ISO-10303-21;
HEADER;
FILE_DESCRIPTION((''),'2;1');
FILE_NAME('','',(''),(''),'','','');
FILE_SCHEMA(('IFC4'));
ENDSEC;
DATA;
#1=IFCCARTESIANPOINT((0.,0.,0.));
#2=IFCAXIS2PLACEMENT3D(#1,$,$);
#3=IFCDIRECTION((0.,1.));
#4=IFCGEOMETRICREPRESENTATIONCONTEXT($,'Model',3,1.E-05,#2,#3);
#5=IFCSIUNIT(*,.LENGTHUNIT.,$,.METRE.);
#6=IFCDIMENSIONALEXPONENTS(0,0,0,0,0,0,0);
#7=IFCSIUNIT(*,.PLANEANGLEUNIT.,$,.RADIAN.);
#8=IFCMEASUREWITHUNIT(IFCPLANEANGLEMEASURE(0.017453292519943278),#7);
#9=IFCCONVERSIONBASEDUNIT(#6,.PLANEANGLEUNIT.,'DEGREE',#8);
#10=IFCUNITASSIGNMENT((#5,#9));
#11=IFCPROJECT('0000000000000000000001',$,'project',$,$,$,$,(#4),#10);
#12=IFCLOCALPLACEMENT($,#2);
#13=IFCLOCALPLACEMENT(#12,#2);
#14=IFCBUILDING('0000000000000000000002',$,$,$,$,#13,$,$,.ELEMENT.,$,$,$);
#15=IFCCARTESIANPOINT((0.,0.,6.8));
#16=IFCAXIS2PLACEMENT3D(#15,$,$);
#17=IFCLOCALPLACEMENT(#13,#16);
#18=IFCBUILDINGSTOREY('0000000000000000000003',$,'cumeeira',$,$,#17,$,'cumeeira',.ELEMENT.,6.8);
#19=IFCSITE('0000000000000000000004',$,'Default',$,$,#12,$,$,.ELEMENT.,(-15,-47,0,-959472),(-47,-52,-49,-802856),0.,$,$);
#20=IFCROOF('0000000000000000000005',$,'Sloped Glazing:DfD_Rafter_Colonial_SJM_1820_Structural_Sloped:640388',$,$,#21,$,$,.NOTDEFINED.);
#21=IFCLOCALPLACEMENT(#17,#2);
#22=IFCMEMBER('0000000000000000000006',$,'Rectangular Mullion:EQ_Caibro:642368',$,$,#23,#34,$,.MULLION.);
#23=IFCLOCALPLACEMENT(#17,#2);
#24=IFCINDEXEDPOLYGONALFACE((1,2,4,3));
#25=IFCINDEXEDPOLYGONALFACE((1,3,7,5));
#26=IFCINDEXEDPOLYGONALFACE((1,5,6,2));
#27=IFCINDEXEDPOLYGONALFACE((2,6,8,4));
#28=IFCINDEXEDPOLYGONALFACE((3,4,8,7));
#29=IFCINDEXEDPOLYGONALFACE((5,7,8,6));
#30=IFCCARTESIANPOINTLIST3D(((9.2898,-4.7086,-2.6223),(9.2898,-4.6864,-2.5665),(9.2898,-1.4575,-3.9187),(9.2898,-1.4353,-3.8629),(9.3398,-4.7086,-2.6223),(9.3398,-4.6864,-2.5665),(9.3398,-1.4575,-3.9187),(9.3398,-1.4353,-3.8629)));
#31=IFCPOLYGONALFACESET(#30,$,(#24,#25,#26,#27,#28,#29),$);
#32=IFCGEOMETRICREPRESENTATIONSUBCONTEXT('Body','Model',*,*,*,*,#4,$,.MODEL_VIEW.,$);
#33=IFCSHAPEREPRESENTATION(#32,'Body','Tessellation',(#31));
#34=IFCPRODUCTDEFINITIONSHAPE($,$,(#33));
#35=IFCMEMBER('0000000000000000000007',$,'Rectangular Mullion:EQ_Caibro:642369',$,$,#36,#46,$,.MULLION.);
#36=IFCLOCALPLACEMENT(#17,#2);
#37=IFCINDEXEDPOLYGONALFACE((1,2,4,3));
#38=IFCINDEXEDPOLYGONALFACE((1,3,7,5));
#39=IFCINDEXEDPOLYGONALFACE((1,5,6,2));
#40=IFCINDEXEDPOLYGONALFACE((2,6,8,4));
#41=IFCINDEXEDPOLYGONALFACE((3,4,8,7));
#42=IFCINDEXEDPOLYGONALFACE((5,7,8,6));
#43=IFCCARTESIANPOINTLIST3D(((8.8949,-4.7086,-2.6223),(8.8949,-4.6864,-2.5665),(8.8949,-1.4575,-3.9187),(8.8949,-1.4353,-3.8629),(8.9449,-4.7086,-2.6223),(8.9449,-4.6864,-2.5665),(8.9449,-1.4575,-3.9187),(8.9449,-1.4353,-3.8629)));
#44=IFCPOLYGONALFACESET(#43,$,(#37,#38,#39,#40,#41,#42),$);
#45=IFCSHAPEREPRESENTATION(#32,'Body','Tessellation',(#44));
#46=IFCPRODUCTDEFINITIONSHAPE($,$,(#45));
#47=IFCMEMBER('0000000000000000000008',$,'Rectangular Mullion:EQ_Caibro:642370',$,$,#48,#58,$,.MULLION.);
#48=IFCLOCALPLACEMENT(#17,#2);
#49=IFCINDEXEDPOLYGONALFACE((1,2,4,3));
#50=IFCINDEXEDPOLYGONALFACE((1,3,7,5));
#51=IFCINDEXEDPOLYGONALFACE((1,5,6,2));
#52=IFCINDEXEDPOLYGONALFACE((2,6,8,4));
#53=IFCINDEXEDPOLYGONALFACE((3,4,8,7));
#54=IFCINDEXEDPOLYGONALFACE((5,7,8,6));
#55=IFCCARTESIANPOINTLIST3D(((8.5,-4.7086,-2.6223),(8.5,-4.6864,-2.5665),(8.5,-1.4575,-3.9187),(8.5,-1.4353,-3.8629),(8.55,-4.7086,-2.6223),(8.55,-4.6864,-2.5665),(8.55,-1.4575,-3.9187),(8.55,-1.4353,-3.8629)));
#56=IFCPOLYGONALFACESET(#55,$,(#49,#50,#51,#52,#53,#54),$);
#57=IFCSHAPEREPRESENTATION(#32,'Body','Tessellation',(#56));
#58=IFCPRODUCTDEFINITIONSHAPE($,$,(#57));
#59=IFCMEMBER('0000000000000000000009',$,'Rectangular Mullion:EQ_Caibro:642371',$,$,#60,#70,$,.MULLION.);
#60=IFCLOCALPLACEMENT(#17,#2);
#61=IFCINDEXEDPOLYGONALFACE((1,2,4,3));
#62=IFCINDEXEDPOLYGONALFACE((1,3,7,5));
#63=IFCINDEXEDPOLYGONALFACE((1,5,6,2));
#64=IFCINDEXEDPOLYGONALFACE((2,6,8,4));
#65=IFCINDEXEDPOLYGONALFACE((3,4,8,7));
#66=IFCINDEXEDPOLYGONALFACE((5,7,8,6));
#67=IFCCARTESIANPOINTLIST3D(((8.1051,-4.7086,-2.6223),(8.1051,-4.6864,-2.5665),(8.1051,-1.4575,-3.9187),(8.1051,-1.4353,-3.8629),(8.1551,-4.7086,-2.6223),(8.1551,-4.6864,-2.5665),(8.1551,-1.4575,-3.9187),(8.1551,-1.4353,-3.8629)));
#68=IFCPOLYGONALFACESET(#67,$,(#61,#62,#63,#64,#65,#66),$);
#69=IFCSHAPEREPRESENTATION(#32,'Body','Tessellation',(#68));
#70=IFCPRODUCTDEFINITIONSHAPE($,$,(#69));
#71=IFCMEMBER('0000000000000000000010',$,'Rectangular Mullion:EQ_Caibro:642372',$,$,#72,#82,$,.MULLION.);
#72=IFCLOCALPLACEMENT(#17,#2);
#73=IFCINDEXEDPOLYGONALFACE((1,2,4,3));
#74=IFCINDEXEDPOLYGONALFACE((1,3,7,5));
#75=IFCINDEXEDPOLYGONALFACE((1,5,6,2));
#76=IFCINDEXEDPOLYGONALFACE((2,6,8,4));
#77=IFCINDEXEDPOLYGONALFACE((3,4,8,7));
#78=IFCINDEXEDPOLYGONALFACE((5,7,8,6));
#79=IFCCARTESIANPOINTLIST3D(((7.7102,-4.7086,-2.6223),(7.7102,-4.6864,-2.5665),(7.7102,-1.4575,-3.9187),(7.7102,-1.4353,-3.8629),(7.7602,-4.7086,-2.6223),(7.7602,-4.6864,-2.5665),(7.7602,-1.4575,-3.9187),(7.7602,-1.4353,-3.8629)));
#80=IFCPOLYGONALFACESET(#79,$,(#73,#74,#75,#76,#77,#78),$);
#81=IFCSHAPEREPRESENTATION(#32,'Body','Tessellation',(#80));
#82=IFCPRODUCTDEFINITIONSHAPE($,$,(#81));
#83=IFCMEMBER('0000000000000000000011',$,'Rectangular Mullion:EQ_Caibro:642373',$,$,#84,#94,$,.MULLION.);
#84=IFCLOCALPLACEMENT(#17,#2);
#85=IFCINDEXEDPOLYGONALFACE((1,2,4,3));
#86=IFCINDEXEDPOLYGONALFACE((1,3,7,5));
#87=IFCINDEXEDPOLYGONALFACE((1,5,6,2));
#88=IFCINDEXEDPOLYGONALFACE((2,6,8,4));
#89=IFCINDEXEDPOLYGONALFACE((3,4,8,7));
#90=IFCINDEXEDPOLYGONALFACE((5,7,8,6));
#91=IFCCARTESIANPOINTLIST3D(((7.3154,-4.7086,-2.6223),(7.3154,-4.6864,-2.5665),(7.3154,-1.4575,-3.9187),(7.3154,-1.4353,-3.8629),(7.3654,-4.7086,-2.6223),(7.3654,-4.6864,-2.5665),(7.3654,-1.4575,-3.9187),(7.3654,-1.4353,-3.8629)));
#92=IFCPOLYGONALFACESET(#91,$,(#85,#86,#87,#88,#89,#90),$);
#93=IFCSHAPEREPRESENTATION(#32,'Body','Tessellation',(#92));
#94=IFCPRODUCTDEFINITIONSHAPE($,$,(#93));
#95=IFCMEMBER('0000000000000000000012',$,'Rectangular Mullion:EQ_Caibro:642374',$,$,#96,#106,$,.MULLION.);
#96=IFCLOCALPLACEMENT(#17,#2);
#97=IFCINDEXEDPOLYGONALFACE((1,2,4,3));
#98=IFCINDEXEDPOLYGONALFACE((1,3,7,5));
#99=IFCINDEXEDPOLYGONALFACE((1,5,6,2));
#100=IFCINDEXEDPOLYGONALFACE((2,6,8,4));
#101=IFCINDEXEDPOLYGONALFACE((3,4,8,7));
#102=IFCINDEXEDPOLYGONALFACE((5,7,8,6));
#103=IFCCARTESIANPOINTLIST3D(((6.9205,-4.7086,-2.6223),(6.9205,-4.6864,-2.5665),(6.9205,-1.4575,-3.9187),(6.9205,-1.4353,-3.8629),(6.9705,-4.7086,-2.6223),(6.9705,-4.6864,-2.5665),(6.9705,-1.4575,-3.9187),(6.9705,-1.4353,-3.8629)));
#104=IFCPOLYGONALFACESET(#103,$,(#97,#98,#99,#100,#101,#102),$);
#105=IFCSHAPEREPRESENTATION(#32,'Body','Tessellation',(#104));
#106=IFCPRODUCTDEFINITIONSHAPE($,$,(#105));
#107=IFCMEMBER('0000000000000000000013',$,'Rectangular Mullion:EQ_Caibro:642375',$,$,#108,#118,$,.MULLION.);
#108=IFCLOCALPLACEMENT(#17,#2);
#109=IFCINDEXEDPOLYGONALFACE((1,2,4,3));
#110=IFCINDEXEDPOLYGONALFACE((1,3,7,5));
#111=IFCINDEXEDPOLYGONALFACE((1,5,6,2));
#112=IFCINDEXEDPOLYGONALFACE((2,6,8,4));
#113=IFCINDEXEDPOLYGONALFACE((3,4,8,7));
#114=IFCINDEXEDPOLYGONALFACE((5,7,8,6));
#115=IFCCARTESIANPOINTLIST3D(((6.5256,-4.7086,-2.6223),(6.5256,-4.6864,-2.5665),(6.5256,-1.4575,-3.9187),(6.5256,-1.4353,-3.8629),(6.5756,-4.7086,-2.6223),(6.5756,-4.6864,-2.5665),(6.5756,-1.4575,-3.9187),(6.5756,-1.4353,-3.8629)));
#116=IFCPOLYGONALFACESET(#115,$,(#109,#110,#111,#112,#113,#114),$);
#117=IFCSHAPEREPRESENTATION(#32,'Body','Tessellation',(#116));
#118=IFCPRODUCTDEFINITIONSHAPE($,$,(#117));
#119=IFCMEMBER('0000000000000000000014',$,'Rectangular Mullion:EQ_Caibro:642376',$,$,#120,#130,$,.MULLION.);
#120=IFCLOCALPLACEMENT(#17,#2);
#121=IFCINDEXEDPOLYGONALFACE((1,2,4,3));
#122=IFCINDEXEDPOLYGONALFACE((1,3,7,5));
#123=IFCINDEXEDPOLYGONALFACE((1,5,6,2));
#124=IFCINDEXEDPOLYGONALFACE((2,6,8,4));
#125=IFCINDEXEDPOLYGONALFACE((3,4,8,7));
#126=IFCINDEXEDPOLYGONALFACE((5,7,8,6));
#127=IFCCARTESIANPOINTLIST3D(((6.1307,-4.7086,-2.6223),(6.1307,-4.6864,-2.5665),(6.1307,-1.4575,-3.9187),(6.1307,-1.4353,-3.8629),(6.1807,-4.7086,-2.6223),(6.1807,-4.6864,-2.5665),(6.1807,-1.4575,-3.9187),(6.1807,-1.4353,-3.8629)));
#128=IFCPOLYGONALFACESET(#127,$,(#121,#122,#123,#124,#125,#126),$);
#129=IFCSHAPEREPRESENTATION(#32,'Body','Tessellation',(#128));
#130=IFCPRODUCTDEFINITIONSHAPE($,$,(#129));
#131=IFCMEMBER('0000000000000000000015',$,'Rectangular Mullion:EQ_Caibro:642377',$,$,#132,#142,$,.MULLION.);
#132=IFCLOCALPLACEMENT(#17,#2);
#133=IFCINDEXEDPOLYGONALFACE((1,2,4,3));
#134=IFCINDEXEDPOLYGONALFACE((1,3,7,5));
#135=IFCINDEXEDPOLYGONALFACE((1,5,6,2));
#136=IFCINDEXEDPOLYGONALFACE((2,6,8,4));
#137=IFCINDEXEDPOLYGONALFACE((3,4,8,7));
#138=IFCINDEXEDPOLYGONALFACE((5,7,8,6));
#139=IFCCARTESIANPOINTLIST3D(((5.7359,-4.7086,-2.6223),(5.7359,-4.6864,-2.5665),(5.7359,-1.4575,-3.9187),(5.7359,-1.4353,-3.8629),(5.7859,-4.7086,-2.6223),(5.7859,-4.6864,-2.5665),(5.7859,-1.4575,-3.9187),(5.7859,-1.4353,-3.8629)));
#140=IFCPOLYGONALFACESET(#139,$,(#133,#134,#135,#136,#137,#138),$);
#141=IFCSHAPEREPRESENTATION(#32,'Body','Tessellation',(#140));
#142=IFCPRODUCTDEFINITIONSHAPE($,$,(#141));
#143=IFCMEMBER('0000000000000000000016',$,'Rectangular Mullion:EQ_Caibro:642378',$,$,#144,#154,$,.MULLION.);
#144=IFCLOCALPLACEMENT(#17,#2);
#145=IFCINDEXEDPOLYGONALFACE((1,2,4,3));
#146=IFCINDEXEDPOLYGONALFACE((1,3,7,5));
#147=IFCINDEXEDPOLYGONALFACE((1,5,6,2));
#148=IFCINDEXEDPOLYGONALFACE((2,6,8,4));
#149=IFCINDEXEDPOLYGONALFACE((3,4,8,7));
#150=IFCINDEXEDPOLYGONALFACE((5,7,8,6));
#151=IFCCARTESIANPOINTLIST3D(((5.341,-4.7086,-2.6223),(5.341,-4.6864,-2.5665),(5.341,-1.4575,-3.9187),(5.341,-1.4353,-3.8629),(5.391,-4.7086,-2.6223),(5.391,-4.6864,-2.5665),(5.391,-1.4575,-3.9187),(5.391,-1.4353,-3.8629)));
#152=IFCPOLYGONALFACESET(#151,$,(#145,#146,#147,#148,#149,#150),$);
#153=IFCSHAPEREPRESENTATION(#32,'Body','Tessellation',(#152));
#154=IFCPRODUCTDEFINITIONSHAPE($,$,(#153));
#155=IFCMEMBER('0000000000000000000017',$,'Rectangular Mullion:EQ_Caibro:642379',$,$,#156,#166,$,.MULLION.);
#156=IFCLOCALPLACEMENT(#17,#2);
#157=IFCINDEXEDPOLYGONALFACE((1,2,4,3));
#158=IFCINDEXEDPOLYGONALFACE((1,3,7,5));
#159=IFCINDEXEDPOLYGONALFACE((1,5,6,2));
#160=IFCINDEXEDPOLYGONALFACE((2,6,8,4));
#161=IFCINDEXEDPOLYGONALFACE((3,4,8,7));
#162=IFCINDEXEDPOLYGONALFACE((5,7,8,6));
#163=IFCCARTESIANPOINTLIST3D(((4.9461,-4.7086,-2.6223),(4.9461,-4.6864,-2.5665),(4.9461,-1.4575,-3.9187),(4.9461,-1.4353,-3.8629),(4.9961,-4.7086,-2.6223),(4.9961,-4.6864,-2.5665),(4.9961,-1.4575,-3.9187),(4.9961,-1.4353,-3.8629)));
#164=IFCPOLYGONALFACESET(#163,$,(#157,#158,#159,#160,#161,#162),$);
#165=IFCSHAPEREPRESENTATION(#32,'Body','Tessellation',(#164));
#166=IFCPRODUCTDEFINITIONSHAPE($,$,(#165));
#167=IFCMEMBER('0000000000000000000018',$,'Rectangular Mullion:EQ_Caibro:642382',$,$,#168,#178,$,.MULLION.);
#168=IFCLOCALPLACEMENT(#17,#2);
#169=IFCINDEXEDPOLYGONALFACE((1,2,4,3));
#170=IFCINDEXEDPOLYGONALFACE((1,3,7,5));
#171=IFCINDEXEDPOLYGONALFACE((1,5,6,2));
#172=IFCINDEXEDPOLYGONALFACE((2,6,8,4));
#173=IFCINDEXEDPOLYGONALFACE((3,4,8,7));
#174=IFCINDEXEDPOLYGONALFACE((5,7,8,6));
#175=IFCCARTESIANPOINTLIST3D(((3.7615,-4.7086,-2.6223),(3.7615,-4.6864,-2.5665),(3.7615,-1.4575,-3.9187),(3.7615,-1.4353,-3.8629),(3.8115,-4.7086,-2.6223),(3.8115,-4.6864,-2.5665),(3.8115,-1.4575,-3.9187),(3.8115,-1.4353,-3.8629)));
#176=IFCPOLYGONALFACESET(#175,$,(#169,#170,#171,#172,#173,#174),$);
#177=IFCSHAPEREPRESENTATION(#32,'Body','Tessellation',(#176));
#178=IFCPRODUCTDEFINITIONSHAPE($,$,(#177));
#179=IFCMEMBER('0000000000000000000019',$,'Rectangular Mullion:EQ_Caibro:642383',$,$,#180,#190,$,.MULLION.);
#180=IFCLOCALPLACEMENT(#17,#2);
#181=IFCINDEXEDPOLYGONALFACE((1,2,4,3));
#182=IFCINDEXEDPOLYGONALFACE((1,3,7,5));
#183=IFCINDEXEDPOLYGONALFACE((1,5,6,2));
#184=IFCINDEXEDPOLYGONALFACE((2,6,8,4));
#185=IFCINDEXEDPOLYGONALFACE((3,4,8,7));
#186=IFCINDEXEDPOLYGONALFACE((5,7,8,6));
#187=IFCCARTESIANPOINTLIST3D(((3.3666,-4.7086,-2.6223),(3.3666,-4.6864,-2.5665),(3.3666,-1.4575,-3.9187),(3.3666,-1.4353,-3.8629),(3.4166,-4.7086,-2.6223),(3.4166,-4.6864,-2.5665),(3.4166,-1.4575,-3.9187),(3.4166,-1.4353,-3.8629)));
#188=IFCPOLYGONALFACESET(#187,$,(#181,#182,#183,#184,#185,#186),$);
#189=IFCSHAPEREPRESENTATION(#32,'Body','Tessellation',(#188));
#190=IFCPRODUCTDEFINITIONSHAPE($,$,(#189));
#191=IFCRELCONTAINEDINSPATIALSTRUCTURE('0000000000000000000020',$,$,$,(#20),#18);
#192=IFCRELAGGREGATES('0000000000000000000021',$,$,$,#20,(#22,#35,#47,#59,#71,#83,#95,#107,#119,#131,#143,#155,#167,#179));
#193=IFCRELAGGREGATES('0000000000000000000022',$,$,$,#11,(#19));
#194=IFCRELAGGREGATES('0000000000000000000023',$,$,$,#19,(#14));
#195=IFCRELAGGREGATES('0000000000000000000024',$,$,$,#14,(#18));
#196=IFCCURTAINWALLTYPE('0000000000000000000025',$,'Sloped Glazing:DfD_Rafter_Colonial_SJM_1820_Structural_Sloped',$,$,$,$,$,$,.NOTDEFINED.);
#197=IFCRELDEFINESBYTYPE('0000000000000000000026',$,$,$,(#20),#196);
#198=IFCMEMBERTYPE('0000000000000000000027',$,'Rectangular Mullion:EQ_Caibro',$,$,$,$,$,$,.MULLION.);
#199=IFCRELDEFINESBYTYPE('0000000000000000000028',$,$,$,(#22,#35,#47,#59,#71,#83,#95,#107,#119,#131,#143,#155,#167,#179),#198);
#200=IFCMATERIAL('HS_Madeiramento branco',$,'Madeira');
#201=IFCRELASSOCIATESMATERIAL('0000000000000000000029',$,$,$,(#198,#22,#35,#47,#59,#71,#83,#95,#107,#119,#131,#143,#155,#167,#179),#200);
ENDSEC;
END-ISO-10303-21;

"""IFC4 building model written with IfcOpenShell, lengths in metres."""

from ifc_helpers import new_model, entity, si_unit, converted_unit, direction, frame, origin, place, context, subcontext, project, spatial, indexed_curve, outline, extrude, source, transform, mapped, material, type_object, type_shapes, element, aggregate, save


model = new_model("IFC4")

# Units and contexts
model_context = context("Model", 3, precision=1e-05, world=origin(), true_north=direction((0.0, 1.0)))
body_context = subcontext(model_context, "Body", "Model", "MODEL_VIEW")
ifc_project = project(units=[si_unit("LENGTHUNIT", "METRE"), converted_unit("PLANEANGLEUNIT", "DEGREE", entity("IfcPlaneAngleMeasure", 0.017453292519943278), si_unit("PLANEANGLEUNIT", "RADIAN"), dimensions=[0, 0, 0, 0, 0, 0, 0])], contexts=[model_context])

# Site, building, storey
site_placement = place(None, origin())
site = spatial("IfcSite", under=ifc_project, at=site_placement, Name="Default", CompositionType="ELEMENT", RefLatitude=(-15, -47, 0, -959472), RefLongitude=(-47, -52, -49, -802856), RefElevation=0.0)
building_placement = place(site_placement, origin())
building = spatial("IfcBuilding", under=site, at=building_placement, CompositionType="ELEMENT")
storey_placement = place(building_placement, frame((0.0, 0.0, 6.8)))
storey = spatial("IfcBuildingStorey", under=building, at=storey_placement, Name="cumeeira", LongName="cumeeira", CompositionType="ELEMENT", Elevation=6.8)

# Roof, members
curtain_wall_type_1 = type_object("IfcCurtainWallType", Name="Sloped Glazing:DfD_Rafter_Colonial_SJM_1820_Structural_Sloped", PredefinedType="NOTDEFINED")
roof_1_placement = place(storey_placement, frame((0.0, 0.0, -6.8)))
roof_1 = element("IfcRoof", 1, at=roof_1_placement, inside=storey, type_object=curtain_wall_type_1, Name="Sloped Glazing:DfD_Rafter_Colonial_SJM_1820_Structural_Sloped:640388", PredefinedType="NOTDEFINED")
ifc_material_1 = material(Name="HS_Madeiramento branco", Category="Madeira")
member_type_1 = type_object("IfcMemberType", Name="Rectangular Mullion:EQ_Caibro", PredefinedType="MULLION", material=ifc_material_1)
shared_shape_1 = source(origin(), body_context, "Body", "SweptSolid", [
    extrude(outline(indexed_curve([(-0.025, -0.03), (0.025, -0.03), (0.025, 0.03), (-0.025, 0.03), (-0.025, -0.03)], self_intersect=False)), frame((0.0, -0.03, -3.5), z_axis=(0.0, 0.0, 1.0), x_axis=(-1.0, 0.0, 0.0)), (0.0, 0.0, 1.0), 3.5),
])
type_shapes(member_type_1, [shared_shape_1])
member_1_placement = place(roof_1_placement, frame((9.3148, -4.7086, 4.1777), z_axis=(0.0, -0.928874, 0.370395), x_axis=(-1.0, 0.0, 0.0)))
member_1 = element("IfcMember", 2, at=member_1_placement, type_object=member_type_1, material=ifc_material_1, Name="Rectangular Mullion:EQ_Caibro:642368", PredefinedType="MULLION", context=body_context, shape_type="MappedRepresentation", body=[
    mapped(shared_shape_1, transform((0.0, 0.0, 0.0), scale=1.0)),
])
member_2_placement = place(roof_1_placement, frame((8.9199, -4.7086, 4.1777), z_axis=(0.0, -0.928874, 0.370395), x_axis=(-1.0, 0.0, 0.0)))
member_2 = element("IfcMember", 3, at=member_2_placement, type_object=member_type_1, material=ifc_material_1, Name="Rectangular Mullion:EQ_Caibro:642369", PredefinedType="MULLION", context=body_context, shape_type="MappedRepresentation", body=[
    mapped(shared_shape_1, transform((0.0, 0.0, 0.0), scale=1.0)),
])
member_3_placement = place(roof_1_placement, frame((8.525, -4.7086, 4.1777), z_axis=(0.0, -0.928874, 0.370395), x_axis=(-1.0, 0.0, 0.0)))
member_3 = element("IfcMember", 4, at=member_3_placement, type_object=member_type_1, material=ifc_material_1, Name="Rectangular Mullion:EQ_Caibro:642370", PredefinedType="MULLION", context=body_context, shape_type="MappedRepresentation", body=[
    mapped(shared_shape_1, transform((0.0, 0.0, 0.0), scale=1.0)),
])
member_4_placement = place(roof_1_placement, frame((8.1301, -4.7086, 4.1777), z_axis=(0.0, -0.928874, 0.370395), x_axis=(-1.0, 0.0, 0.0)))
member_4 = element("IfcMember", 5, at=member_4_placement, type_object=member_type_1, material=ifc_material_1, Name="Rectangular Mullion:EQ_Caibro:642371", PredefinedType="MULLION", context=body_context, shape_type="MappedRepresentation", body=[
    mapped(shared_shape_1, transform((0.0, 0.0, 0.0), scale=1.0)),
])
member_5_placement = place(roof_1_placement, frame((7.7352, -4.7086, 4.1777), z_axis=(0.0, -0.928874, 0.370395), x_axis=(-1.0, 0.0, 0.0)))
member_5 = element("IfcMember", 6, at=member_5_placement, type_object=member_type_1, material=ifc_material_1, Name="Rectangular Mullion:EQ_Caibro:642372", PredefinedType="MULLION", context=body_context, shape_type="MappedRepresentation", body=[
    mapped(shared_shape_1, transform((0.0, 0.0, 0.0), scale=1.0)),
])
member_6_placement = place(roof_1_placement, frame((7.3404, -4.7086, 4.1777), z_axis=(0.0, -0.928874, 0.370395), x_axis=(-1.0, 0.0, 0.0)))
member_6 = element("IfcMember", 7, at=member_6_placement, type_object=member_type_1, material=ifc_material_1, Name="Rectangular Mullion:EQ_Caibro:642373", PredefinedType="MULLION", context=body_context, shape_type="MappedRepresentation", body=[
    mapped(shared_shape_1, transform((0.0, 0.0, 0.0), scale=1.0)),
])
member_7_placement = place(roof_1_placement, frame((6.9455, -4.7086, 4.1777), z_axis=(0.0, -0.928874, 0.370395), x_axis=(-1.0, 0.0, 0.0)))
member_7 = element("IfcMember", 8, at=member_7_placement, type_object=member_type_1, material=ifc_material_1, Name="Rectangular Mullion:EQ_Caibro:642374", PredefinedType="MULLION", context=body_context, shape_type="MappedRepresentation", body=[
    mapped(shared_shape_1, transform((0.0, 0.0, 0.0), scale=1.0)),
])
member_8_placement = place(roof_1_placement, frame((6.5506, -4.7086, 4.1777), z_axis=(0.0, -0.928874, 0.370395), x_axis=(-1.0, 0.0, 0.0)))
member_8 = element("IfcMember", 9, at=member_8_placement, type_object=member_type_1, material=ifc_material_1, Name="Rectangular Mullion:EQ_Caibro:642375", PredefinedType="MULLION", context=body_context, shape_type="MappedRepresentation", body=[
    mapped(shared_shape_1, transform((0.0, 0.0, 0.0), scale=1.0)),
])
member_9_placement = place(roof_1_placement, frame((6.1557, -4.7086, 4.1777), z_axis=(0.0, -0.928874, 0.370395), x_axis=(-1.0, 0.0, 0.0)))
member_9 = element("IfcMember", 10, at=member_9_placement, type_object=member_type_1, material=ifc_material_1, Name="Rectangular Mullion:EQ_Caibro:642376", PredefinedType="MULLION", context=body_context, shape_type="MappedRepresentation", body=[
    mapped(shared_shape_1, transform((0.0, 0.0, 0.0), scale=1.0)),
])
member_10_placement = place(roof_1_placement, frame((5.7609, -4.7086, 4.1777), z_axis=(0.0, -0.928874, 0.370395), x_axis=(-1.0, 0.0, 0.0)))
member_10 = element("IfcMember", 11, at=member_10_placement, type_object=member_type_1, material=ifc_material_1, Name="Rectangular Mullion:EQ_Caibro:642377", PredefinedType="MULLION", context=body_context, shape_type="MappedRepresentation", body=[
    mapped(shared_shape_1, transform((0.0, 0.0, 0.0), scale=1.0)),
])
member_11_placement = place(roof_1_placement, frame((5.366, -4.7086, 4.1777), z_axis=(0.0, -0.928874, 0.370395), x_axis=(-1.0, 0.0, 0.0)))
member_11 = element("IfcMember", 12, at=member_11_placement, type_object=member_type_1, material=ifc_material_1, Name="Rectangular Mullion:EQ_Caibro:642378", PredefinedType="MULLION", context=body_context, shape_type="MappedRepresentation", body=[
    mapped(shared_shape_1, transform((0.0, 0.0, 0.0), scale=1.0)),
])
member_12_placement = place(roof_1_placement, frame((4.9711, -4.7086, 4.1777), z_axis=(0.0, -0.928874, 0.370395), x_axis=(-1.0, 0.0, 0.0)))
member_12 = element("IfcMember", 13, at=member_12_placement, type_object=member_type_1, material=ifc_material_1, Name="Rectangular Mullion:EQ_Caibro:642379", PredefinedType="MULLION", context=body_context, shape_type="MappedRepresentation", body=[
    mapped(shared_shape_1, transform((0.0, 0.0, 0.0), scale=1.0)),
])
member_13_placement = place(roof_1_placement, frame((3.7865, -4.7086, 4.1777), z_axis=(0.0, -0.928874, 0.370395), x_axis=(-1.0, 0.0, 0.0)))
member_13 = element("IfcMember", 14, at=member_13_placement, type_object=member_type_1, material=ifc_material_1, Name="Rectangular Mullion:EQ_Caibro:642382", PredefinedType="MULLION", context=body_context, shape_type="MappedRepresentation", body=[
    mapped(shared_shape_1, transform((0.0, 0.0, 0.0), scale=1.0)),
])
member_14_placement = place(roof_1_placement, frame((3.3916, -4.7086, 4.1777), z_axis=(0.0, -0.928874, 0.370395), x_axis=(-1.0, 0.0, 0.0)))
member_14 = element("IfcMember", 15, at=member_14_placement, type_object=member_type_1, material=ifc_material_1, Name="Rectangular Mullion:EQ_Caibro:642383", PredefinedType="MULLION", context=body_context, shape_type="MappedRepresentation", body=[
    mapped(shared_shape_1, transform((0.0, 0.0, 0.0), scale=1.0)),
])
aggregate(roof_1, [member_1, member_2, member_3, member_4, member_5, member_6, member_7, member_8, member_9, member_10, member_11, member_12, member_13, member_14])

save(model, "model.ifc")
